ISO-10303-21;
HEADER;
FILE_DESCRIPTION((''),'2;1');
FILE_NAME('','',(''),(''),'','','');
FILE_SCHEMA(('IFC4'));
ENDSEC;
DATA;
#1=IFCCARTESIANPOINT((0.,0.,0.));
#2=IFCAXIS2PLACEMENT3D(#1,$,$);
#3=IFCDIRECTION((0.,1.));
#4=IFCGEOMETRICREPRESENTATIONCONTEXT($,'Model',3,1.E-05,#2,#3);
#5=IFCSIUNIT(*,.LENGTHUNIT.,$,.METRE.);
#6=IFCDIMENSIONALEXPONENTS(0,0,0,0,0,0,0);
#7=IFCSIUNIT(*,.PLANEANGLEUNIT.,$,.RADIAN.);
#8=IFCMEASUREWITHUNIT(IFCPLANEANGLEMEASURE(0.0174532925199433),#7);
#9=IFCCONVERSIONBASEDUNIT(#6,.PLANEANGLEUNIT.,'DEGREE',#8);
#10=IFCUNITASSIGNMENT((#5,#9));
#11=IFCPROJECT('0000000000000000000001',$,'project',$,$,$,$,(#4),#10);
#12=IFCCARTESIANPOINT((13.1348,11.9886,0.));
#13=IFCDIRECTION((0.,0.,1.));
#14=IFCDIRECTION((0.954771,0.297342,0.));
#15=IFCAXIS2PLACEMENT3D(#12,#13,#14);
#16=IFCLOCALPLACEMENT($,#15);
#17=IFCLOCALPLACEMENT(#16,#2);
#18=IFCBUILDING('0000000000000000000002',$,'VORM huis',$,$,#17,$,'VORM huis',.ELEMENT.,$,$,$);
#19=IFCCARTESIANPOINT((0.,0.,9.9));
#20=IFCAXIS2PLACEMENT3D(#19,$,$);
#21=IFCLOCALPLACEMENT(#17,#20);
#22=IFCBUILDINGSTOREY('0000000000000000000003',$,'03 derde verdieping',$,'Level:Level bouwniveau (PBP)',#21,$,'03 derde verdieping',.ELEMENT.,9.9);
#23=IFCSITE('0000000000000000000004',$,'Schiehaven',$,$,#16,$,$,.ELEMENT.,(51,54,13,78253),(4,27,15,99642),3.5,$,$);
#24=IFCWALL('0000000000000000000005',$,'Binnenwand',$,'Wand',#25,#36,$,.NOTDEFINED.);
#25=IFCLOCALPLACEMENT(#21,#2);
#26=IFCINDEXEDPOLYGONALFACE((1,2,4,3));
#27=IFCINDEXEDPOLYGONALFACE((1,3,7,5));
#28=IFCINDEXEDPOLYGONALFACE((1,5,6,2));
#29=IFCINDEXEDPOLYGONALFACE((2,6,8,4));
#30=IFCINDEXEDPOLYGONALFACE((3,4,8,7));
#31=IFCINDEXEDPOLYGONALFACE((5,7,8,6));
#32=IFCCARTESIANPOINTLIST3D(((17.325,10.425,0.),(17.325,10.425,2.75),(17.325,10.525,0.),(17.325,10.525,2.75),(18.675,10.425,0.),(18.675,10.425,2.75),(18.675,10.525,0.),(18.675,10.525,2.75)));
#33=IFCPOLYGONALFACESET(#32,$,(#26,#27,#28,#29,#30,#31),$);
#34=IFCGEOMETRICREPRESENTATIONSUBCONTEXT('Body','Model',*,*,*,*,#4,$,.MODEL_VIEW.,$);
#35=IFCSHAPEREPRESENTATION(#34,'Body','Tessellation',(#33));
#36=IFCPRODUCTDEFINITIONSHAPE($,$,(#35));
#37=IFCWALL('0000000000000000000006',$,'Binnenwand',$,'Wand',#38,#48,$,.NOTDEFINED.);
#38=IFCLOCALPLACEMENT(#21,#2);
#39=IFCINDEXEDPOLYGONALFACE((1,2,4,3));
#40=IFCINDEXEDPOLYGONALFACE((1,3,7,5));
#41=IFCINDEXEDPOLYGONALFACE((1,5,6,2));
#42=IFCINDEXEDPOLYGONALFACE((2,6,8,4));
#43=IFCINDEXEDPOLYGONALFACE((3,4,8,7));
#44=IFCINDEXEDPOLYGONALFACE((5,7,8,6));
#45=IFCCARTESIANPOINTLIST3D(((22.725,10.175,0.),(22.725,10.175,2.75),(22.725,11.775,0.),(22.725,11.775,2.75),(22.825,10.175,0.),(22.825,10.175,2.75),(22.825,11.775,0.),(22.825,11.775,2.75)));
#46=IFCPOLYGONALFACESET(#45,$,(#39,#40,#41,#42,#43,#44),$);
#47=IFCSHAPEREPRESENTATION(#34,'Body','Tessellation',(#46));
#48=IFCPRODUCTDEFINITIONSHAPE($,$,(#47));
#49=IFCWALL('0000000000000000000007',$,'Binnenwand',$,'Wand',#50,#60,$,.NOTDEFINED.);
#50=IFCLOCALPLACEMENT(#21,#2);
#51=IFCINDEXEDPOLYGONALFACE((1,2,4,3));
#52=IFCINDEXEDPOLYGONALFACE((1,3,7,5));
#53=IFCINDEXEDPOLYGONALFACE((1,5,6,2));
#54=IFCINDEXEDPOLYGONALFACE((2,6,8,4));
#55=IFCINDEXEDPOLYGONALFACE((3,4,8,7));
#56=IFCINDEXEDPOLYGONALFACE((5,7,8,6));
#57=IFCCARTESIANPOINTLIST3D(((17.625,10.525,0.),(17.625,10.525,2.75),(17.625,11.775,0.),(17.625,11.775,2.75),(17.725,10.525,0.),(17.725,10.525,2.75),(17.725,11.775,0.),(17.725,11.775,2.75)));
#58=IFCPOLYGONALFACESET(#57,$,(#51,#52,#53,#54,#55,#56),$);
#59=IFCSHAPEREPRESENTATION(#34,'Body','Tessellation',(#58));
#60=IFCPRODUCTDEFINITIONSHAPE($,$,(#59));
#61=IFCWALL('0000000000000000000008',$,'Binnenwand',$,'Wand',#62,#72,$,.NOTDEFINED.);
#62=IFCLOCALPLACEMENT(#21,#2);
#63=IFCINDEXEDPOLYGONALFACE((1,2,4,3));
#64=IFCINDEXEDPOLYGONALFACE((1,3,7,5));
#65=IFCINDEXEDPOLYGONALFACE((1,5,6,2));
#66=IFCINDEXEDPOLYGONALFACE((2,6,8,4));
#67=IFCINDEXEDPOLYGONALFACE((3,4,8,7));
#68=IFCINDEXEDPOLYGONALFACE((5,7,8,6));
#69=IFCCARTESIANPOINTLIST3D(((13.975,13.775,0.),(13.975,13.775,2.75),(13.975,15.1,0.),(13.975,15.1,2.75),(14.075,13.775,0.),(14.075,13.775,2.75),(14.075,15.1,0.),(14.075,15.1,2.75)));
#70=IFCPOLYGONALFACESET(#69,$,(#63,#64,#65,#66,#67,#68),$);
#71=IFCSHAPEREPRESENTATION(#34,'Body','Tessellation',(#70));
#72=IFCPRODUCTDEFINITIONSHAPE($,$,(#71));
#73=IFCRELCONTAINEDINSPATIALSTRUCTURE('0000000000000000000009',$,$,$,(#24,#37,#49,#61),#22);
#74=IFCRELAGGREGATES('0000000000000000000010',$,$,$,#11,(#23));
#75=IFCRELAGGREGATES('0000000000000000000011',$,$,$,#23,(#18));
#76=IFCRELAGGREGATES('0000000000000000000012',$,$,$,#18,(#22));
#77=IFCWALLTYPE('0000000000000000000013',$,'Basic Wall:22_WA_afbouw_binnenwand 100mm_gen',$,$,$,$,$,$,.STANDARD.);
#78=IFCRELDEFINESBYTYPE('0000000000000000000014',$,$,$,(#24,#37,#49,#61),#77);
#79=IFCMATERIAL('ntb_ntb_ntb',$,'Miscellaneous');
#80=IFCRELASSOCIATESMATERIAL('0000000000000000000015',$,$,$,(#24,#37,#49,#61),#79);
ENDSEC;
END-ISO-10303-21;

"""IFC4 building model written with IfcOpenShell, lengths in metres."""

from ifc_helpers import new_model, entity, si_unit, converted_unit, direction, frame, origin, place, context, subcontext, project, spatial, indexed_curve, outline, extrude, material, type_object, element, save


model = new_model("IFC4")

# Units and contexts
model_context = context("Model", 3, precision=1e-05, world=origin(), true_north=direction((0.0, 1.0)))
body_context = subcontext(model_context, "Body", "Model", "MODEL_VIEW")
ifc_project = project(units=[si_unit("LENGTHUNIT", "METRE"), converted_unit("PLANEANGLEUNIT", "DEGREE", entity("IfcPlaneAngleMeasure", 0.0174532925199433), si_unit("PLANEANGLEUNIT", "RADIAN"), dimensions=[0, 0, 0, 0, 0, 0, 0])], contexts=[model_context])

# Site, building, storey
site_placement = place(None, frame((13.1348, 11.9886, 0.0), z_axis=(0.0, 0.0, 1.0), x_axis=(0.954771, 0.297342, 0.0)))
site = spatial("IfcSite", under=ifc_project, at=site_placement, Name="Schiehaven", CompositionType="ELEMENT", RefLatitude=(51, 54, 13, 78253), RefLongitude=(4, 27, 15, 99642), RefElevation=3.5)
building_placement = place(site_placement, origin())
building = spatial("IfcBuilding", under=site, at=building_placement, Name="VORM huis", LongName="VORM huis", CompositionType="ELEMENT")
storey_placement = place(building_placement, frame((0.0, 0.0, 9.9)))
storey = spatial("IfcBuildingStorey", under=building, at=storey_placement, Name="03 derde verdieping", ObjectType="Level:Level bouwniveau (PBP)", LongName="03 derde verdieping", CompositionType="ELEMENT", Elevation=9.9)

# Walls
ifc_material_1 = material(Name="ntb_ntb_ntb", Category="Miscellaneous")
wall_type_1 = type_object("IfcWallType", Name="Basic Wall:22_WA_afbouw_binnenwand 100mm_gen", PredefinedType="STANDARD")
wall_1_placement = place(storey_placement, frame((17.325, 10.475, 0.0)))
element("IfcWall", 1, at=wall_1_placement, inside=storey, type_object=wall_type_1, material=ifc_material_1, Name="Binnenwand", ObjectType="Wand", PredefinedType="NOTDEFINED", context=body_context, shape_type="SweptSolid", body=[
    extrude(outline(indexed_curve([(1.35, 0.05), (0.0, 0.05), (0.0, -0.05), (1.35, -0.05), (1.35, 0.05)], self_intersect=False)), origin(), (0.0, 0.0, 1.0), 2.75),
])
wall_2_placement = place(storey_placement, frame((22.775, 10.175, 0.0), z_axis=(0.0, 0.0, 1.0), x_axis=(0.0, 1.0, 0.0)))
element("IfcWall", 2, at=wall_2_placement, inside=storey, type_object=wall_type_1, material=ifc_material_1, Name="Binnenwand", ObjectType="Wand", PredefinedType="NOTDEFINED", context=body_context, shape_type="SweptSolid", body=[
    extrude(outline(indexed_curve([(1.6, 0.05), (0.0, 0.05), (0.0, -0.05), (1.6, -0.05), (1.6, 0.05)], self_intersect=False)), origin(), (0.0, 0.0, 1.0), 2.75),
])
wall_3_placement = place(storey_placement, frame((17.675, 11.775, 0.0), z_axis=(0.0, 0.0, 1.0), x_axis=(0.0, -1.0, 0.0)))
element("IfcWall", 3, at=wall_3_placement, inside=storey, type_object=wall_type_1, material=ifc_material_1, Name="Binnenwand", ObjectType="Wand", PredefinedType="NOTDEFINED", context=body_context, shape_type="SweptSolid", body=[
    extrude(outline(indexed_curve([(1.25, 0.05), (0.0, 0.05), (0.0, -0.05), (1.25, -0.05), (1.25, 0.05)], self_intersect=False)), origin(), (0.0, 0.0, 1.0), 2.75),
])
wall_4_placement = place(storey_placement, frame((14.025, 13.775, 0.0), z_axis=(0.0, 0.0, 1.0), x_axis=(0.0, 1.0, 0.0)))
element("IfcWall", 4, at=wall_4_placement, inside=storey, type_object=wall_type_1, material=ifc_material_1, Name="Binnenwand", ObjectType="Wand", PredefinedType="NOTDEFINED", context=body_context, shape_type="SweptSolid", body=[
    extrude(outline(indexed_curve([(1.325, 0.05), (0.0, 0.05), (0.0, -0.05), (1.325, -0.05), (1.325, 0.05)], self_intersect=False)), origin(), (0.0, 0.0, 1.0), 2.75),
])

save(model, "model.ifc")
